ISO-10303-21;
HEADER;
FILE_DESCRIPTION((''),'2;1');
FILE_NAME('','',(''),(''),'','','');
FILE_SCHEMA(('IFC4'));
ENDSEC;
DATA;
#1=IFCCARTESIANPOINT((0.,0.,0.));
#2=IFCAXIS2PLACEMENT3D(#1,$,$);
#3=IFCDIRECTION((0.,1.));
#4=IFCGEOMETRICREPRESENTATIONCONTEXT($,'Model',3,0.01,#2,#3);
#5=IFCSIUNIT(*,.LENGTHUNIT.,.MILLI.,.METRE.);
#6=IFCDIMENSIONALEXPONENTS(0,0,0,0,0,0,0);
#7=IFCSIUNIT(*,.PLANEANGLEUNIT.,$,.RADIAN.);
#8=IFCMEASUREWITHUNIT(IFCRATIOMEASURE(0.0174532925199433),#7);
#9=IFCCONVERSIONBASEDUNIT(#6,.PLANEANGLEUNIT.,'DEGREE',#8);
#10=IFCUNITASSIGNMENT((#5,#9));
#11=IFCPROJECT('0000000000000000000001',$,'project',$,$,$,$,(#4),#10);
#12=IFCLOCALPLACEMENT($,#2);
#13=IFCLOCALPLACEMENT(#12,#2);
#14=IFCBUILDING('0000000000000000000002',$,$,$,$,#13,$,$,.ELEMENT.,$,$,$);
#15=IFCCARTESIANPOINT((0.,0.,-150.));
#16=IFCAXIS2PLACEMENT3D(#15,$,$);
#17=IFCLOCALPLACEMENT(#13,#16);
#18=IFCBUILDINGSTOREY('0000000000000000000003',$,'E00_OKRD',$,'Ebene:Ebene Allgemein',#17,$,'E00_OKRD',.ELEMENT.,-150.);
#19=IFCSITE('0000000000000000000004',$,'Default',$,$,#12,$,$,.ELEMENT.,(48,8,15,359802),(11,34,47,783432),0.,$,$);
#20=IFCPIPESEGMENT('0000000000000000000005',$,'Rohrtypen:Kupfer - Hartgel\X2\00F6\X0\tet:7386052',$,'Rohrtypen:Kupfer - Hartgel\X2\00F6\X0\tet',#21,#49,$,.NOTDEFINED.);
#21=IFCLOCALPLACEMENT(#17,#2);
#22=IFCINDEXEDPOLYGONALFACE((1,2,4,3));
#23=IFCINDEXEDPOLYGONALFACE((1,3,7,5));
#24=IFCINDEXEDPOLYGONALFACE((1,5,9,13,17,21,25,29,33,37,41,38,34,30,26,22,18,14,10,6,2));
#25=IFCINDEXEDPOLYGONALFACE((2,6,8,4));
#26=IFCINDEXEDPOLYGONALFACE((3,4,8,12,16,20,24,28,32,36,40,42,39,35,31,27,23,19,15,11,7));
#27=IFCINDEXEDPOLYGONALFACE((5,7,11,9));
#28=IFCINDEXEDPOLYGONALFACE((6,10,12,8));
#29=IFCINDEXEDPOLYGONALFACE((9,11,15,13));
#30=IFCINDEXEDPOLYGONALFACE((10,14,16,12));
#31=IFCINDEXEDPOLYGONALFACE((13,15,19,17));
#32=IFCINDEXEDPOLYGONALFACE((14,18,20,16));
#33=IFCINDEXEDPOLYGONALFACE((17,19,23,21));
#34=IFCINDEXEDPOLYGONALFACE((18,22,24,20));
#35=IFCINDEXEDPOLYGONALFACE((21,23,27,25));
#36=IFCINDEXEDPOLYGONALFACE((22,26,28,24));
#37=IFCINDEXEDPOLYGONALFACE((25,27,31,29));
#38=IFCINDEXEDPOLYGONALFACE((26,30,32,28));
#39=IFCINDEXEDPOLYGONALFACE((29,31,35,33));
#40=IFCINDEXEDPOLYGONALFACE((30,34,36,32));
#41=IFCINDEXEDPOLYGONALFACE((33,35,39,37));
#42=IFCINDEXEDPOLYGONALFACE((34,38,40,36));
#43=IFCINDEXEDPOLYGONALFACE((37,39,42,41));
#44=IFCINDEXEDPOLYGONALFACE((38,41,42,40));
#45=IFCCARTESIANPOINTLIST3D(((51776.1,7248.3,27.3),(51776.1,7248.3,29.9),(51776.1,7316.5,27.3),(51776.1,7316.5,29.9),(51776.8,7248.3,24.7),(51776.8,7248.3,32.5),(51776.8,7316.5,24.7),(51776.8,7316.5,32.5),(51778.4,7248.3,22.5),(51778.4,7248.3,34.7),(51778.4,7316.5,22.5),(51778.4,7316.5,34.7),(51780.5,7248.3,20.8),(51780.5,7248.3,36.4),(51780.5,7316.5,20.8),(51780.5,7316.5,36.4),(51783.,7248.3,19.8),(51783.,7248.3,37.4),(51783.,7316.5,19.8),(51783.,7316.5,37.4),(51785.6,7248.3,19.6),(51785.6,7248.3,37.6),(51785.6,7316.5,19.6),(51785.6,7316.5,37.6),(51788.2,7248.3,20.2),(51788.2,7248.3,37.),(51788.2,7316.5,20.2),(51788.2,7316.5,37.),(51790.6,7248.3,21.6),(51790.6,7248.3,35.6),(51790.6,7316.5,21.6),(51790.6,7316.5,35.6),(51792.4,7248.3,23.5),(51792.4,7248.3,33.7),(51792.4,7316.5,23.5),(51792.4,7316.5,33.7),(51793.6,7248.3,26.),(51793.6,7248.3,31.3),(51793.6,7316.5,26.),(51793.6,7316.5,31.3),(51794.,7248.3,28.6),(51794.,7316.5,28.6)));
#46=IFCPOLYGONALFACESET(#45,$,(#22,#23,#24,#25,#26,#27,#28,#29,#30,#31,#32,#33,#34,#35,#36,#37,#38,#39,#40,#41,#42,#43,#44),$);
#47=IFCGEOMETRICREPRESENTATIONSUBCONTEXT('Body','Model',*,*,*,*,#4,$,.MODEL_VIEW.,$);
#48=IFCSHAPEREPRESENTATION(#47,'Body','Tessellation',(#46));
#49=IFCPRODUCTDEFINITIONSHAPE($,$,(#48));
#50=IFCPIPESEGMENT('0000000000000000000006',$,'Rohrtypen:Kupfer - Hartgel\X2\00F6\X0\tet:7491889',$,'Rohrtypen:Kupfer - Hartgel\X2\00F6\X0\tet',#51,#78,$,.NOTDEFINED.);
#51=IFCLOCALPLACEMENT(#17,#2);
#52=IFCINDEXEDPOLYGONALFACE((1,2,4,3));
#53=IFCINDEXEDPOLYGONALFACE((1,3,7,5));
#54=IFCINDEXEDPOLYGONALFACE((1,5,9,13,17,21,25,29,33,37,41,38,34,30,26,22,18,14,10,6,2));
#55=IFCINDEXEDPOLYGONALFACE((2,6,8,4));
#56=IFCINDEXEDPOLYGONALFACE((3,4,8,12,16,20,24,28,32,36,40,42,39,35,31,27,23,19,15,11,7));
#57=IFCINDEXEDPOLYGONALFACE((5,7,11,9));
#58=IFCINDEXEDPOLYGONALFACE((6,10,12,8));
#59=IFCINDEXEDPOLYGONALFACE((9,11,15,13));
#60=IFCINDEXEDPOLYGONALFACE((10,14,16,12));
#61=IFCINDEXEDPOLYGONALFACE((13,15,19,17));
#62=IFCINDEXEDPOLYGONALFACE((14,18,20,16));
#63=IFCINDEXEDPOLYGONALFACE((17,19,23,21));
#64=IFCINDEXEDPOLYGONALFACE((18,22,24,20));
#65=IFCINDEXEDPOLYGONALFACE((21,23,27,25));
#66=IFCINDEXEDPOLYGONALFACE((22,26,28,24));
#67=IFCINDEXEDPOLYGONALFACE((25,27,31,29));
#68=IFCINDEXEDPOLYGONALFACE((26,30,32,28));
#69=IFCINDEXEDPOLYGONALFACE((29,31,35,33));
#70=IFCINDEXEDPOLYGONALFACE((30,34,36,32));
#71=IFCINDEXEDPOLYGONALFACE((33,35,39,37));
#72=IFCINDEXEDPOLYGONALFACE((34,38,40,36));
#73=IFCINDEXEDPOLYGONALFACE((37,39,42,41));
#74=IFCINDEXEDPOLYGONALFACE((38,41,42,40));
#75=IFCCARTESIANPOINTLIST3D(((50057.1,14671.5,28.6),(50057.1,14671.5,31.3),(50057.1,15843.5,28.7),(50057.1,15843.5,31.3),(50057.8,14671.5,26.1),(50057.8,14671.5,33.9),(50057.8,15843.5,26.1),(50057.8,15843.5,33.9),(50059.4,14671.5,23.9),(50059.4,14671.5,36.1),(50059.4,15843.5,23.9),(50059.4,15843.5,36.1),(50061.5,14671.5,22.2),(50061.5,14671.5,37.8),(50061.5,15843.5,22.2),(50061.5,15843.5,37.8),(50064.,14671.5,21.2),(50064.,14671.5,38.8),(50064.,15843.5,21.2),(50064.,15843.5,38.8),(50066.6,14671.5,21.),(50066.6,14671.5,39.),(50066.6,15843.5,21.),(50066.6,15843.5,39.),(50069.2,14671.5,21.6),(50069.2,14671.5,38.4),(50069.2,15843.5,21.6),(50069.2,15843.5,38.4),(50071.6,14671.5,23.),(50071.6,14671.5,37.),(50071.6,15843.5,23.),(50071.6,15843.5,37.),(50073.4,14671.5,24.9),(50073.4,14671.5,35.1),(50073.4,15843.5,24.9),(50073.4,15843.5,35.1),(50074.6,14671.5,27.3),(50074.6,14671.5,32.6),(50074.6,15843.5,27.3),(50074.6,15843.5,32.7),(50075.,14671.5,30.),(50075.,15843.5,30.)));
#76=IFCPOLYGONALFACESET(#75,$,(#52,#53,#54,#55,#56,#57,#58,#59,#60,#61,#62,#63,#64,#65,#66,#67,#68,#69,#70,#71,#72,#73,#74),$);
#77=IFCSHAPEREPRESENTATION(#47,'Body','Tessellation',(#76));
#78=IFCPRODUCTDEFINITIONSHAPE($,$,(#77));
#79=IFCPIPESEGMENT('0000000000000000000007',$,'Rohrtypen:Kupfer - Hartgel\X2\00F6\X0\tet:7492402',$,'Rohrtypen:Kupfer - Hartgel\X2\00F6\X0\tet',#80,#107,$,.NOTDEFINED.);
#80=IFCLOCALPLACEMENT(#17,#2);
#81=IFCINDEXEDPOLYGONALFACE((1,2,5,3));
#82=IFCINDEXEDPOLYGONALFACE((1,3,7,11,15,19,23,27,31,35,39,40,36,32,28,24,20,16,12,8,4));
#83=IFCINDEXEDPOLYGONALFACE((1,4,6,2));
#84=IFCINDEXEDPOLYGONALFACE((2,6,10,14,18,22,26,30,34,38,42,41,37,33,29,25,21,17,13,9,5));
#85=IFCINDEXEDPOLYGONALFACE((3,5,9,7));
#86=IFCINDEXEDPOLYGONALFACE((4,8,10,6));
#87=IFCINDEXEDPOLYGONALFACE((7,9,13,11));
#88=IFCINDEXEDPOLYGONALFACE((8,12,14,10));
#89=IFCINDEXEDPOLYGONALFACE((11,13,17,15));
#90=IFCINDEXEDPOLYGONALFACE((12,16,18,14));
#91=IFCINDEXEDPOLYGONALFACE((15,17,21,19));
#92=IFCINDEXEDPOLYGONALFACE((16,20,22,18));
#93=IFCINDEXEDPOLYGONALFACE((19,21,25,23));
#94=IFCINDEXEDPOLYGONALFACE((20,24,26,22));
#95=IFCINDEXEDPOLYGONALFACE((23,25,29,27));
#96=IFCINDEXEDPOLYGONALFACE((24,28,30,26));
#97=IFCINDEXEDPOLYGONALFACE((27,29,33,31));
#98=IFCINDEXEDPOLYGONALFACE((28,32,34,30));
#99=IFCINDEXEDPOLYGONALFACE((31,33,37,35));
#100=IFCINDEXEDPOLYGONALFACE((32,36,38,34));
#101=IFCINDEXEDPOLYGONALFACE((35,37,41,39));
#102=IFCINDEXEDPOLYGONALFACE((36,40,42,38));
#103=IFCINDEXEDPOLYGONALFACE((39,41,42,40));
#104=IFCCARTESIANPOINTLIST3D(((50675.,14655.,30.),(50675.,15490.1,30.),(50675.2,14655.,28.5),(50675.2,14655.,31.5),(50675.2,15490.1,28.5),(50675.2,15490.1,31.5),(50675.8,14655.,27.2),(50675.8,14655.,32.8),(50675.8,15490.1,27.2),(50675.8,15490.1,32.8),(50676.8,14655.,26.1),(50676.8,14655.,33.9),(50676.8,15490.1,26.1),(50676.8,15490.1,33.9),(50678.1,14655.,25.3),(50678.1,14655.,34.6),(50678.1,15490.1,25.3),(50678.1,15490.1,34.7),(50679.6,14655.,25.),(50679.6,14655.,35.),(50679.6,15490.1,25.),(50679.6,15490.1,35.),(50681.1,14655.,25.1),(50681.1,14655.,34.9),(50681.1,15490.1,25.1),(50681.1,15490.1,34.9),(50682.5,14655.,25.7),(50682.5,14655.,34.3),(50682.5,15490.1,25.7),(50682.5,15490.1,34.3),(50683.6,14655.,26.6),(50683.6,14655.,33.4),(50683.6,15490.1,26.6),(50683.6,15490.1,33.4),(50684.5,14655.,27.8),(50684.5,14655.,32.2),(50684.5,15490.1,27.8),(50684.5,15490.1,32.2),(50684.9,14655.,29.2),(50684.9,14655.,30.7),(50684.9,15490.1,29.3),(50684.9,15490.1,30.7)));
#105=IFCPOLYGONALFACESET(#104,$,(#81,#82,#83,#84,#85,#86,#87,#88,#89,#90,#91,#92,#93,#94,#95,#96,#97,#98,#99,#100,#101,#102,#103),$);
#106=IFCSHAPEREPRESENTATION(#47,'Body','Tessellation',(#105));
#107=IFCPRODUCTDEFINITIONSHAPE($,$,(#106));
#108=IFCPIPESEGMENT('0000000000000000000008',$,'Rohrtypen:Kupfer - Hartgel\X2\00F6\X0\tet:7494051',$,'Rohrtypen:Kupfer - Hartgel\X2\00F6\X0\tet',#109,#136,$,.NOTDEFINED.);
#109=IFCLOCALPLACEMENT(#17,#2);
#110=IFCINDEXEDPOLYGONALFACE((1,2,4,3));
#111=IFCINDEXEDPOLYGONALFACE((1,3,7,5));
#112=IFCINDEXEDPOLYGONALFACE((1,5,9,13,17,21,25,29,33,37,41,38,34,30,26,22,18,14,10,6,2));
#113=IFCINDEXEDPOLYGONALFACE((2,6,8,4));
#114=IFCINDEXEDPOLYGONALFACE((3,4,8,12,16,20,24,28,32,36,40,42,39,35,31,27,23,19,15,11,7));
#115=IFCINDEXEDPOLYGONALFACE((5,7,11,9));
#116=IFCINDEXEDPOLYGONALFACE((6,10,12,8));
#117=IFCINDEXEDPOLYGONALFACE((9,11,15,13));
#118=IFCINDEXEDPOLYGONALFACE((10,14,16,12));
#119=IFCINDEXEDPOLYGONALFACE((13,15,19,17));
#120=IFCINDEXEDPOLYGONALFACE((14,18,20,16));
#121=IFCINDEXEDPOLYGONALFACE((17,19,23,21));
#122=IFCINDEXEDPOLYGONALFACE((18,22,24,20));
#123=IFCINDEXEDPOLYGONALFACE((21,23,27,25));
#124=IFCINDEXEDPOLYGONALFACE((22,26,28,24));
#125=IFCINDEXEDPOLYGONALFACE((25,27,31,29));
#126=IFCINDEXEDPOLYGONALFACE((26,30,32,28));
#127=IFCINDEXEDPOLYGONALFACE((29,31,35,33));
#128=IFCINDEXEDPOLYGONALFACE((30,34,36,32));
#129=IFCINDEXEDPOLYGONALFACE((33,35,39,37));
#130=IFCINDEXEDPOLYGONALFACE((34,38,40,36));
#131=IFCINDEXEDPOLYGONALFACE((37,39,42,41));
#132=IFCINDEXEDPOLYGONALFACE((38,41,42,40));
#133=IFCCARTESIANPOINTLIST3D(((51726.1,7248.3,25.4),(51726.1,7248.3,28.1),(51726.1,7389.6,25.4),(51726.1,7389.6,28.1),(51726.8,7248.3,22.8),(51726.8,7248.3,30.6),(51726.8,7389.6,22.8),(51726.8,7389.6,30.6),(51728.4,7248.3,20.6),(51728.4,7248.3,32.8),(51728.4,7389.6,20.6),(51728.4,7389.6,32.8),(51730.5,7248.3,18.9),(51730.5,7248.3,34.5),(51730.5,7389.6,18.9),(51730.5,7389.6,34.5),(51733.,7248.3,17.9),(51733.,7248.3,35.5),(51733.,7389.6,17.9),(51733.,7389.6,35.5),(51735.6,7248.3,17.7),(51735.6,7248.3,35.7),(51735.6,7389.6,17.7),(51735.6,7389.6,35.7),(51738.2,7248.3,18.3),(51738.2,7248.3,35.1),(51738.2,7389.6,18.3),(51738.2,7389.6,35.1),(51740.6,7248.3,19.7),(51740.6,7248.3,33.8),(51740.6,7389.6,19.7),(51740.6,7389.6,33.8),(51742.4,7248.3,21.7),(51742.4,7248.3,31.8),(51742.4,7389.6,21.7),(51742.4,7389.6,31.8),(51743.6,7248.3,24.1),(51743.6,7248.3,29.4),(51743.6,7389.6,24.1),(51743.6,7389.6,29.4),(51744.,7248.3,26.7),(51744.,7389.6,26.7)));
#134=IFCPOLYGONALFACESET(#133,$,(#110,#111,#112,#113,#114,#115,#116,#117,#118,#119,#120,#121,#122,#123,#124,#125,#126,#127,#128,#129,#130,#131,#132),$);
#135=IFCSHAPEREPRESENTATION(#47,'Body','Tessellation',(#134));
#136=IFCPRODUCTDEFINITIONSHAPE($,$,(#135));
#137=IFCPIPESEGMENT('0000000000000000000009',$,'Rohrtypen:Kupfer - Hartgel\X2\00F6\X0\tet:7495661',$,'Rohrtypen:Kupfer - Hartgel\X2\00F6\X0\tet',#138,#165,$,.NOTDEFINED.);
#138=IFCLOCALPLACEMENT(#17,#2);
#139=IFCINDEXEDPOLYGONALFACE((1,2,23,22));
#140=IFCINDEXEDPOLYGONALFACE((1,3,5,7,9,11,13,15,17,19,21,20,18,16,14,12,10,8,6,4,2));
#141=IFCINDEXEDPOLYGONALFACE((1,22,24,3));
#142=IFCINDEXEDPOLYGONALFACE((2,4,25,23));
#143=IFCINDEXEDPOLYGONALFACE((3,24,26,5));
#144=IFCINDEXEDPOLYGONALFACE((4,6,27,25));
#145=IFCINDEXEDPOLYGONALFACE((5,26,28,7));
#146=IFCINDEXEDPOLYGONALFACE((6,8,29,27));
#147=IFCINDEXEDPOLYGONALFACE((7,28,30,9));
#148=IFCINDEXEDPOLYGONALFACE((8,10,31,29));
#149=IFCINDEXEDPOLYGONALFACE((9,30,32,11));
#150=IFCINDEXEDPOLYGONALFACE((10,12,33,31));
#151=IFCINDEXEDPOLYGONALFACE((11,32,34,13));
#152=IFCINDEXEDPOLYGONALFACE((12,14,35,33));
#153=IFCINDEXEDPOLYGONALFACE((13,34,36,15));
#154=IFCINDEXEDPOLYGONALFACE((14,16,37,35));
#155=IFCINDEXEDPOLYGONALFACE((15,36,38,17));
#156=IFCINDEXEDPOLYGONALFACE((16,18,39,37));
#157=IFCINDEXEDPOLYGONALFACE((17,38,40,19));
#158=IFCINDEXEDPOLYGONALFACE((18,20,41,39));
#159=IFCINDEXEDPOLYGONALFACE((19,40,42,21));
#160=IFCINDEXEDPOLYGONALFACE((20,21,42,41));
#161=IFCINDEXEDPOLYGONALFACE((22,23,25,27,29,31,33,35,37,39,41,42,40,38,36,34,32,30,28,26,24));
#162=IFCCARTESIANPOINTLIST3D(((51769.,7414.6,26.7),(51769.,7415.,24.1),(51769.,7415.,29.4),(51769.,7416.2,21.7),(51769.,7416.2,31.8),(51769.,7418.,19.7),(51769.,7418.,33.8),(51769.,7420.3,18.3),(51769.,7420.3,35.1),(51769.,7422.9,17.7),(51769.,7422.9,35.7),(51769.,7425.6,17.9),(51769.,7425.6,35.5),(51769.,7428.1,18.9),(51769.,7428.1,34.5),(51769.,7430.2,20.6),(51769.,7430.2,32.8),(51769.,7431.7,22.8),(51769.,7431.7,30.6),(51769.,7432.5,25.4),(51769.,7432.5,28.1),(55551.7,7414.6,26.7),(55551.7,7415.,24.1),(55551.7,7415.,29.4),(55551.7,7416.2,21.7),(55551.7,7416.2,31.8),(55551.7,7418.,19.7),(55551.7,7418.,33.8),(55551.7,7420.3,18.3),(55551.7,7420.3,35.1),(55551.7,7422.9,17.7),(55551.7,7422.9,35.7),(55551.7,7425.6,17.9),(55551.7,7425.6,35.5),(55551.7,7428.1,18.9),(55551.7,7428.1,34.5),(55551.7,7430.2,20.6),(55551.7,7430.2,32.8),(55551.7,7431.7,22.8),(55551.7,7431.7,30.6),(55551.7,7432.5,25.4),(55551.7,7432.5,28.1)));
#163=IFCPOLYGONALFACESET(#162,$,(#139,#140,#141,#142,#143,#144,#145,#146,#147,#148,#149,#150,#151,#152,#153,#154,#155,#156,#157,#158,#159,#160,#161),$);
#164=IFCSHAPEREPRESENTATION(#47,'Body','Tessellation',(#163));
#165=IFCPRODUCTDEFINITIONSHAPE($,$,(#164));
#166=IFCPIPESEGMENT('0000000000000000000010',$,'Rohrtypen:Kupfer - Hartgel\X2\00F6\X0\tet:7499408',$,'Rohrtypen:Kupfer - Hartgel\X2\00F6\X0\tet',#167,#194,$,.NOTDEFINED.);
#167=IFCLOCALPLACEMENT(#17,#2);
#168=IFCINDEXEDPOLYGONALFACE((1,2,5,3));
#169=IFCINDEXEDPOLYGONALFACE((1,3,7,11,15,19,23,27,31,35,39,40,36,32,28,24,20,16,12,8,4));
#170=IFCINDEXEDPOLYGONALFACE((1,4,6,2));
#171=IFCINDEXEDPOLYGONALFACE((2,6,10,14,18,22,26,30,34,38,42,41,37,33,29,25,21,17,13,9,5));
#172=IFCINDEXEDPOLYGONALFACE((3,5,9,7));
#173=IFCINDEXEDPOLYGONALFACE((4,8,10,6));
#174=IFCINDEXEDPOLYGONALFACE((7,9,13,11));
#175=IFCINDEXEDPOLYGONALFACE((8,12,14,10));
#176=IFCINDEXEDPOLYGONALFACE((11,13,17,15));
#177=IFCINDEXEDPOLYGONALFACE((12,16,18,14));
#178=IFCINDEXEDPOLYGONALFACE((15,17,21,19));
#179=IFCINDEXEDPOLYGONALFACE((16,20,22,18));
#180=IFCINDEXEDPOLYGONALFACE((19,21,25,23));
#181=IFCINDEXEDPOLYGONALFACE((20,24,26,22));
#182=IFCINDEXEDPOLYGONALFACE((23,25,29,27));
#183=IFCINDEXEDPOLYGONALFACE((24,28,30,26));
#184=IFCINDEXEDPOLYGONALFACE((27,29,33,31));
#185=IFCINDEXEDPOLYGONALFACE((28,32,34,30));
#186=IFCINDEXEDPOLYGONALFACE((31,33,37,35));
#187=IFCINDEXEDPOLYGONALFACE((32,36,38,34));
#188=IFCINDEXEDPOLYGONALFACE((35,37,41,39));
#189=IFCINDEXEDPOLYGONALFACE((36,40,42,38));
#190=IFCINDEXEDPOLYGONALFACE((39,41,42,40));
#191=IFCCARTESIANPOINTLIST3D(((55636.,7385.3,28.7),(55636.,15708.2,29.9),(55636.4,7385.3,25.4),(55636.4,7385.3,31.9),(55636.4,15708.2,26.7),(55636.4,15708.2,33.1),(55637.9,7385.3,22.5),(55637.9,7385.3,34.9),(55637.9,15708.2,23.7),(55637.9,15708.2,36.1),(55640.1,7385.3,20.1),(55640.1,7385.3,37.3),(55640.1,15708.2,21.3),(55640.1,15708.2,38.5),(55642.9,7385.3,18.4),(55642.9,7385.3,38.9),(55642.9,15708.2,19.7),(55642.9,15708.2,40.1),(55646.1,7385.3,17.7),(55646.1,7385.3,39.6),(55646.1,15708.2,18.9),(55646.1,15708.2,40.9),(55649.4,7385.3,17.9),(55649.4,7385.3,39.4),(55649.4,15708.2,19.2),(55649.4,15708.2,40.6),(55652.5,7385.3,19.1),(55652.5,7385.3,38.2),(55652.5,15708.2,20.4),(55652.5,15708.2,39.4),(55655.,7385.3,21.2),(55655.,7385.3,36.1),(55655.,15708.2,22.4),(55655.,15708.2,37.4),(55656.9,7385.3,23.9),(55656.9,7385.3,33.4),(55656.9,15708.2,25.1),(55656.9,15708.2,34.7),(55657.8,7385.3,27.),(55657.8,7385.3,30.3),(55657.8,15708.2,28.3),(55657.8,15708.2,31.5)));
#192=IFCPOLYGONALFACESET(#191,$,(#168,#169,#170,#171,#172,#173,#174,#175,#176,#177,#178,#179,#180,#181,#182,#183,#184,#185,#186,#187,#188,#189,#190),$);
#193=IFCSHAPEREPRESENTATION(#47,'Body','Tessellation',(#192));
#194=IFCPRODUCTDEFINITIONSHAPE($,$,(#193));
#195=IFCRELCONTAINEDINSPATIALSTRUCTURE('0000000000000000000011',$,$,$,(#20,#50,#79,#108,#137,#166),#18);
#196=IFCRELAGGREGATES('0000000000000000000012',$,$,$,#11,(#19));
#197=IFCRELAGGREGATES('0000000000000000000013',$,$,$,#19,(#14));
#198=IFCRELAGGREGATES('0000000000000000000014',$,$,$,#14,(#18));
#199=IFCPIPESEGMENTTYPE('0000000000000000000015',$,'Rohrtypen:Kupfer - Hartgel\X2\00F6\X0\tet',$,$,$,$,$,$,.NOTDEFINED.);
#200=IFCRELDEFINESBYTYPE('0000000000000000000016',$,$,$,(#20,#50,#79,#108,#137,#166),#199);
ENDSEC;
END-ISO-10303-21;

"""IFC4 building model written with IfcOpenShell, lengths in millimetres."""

from ifc_helpers import new_model, entity, si_unit, converted_unit, direction, frame, frame_2d, origin, origin_2d_with_axis, place, context, subcontext, project, spatial, circle, extrude, type_object, element, save


model = new_model("IFC4")

# Units and contexts
model_context = context("Model", 3, precision=0.01, world=origin(), true_north=direction((0.0, 1.0)))
body_context = subcontext(model_context, "Body", "Model", "MODEL_VIEW")
ifc_project = project(units=[si_unit("LENGTHUNIT", "METRE", prefix="MILLI"), converted_unit("PLANEANGLEUNIT", "DEGREE", entity("IfcRatioMeasure", 0.0174532925199433), si_unit("PLANEANGLEUNIT", "RADIAN"), dimensions=[0, 0, 0, 0, 0, 0, 0])], contexts=[model_context])

# Site, building, storey
site_placement = place(None, origin())
site = spatial("IfcSite", under=ifc_project, at=site_placement, Name="Default", CompositionType="ELEMENT", RefLatitude=(48, 8, 15, 359802), RefLongitude=(11, 34, 47, 783432), RefElevation=0.0)
building_placement = place(site_placement, origin())
building = spatial("IfcBuilding", under=site, at=building_placement, CompositionType="ELEMENT")
storey_placement = place(building_placement, frame((0.0, 0.0, -150.0)))
storey = spatial("IfcBuildingStorey", under=building, at=storey_placement, Name="E00_OKRD", ObjectType="Ebene:Ebene Allgemein", LongName="E00_OKRD", CompositionType="ELEMENT", Elevation=-150.0)

# Pipe segments
pipe_segment_type = type_object("IfcPipeSegmentType", Name="Rohrtypen:Kupfer - Hartgelötet", PredefinedType="NOTDEFINED")
pipe_segment_1_placement = place(storey_placement, frame((51774.4, 7248.3, 18.0)))
element("IfcPipeSegment", 1, at=pipe_segment_1_placement, inside=storey, type_object=pipe_segment_type, Name="Rohrtypen:Kupfer - Hartgelötet:7386052", ObjectType="Rohrtypen:Kupfer - Hartgelötet", PredefinedType="NOTDEFINED", context=body_context, shape_type="SweptSolid", body=[
    extrude(circle(Radius=9.0, at=frame_2d((0.0, 0.0), x_axis=(1.0, 0.0))), frame((10.6, 0.0, 10.6), z_axis=(0.0, 1.0, 0.0), x_axis=(1.0, 0.0, 0.0)), (0.0, 0.0, 1.0), 68.2),
])
pipe_segment_2_placement = place(storey_placement, frame((50055.4, 14671.5, 19.4)))
element("IfcPipeSegment", 2, at=pipe_segment_2_placement, inside=storey, type_object=pipe_segment_type, Name="Rohrtypen:Kupfer - Hartgelötet:7491889", ObjectType="Rohrtypen:Kupfer - Hartgelötet", PredefinedType="NOTDEFINED", context=body_context, shape_type="SweptSolid", body=[
    extrude(circle(Radius=9.0, at=origin_2d_with_axis()), frame((10.6, 0.0, 10.6), z_axis=(0.0, 1.0, 0.000011), x_axis=(1.0, 0.0, 0.0)), (0.0, 0.0, 1.0), 1172.0),
])
pipe_segment_3_placement = place(storey_placement, frame((50673.4, 14655.0, 23.4)))
element("IfcPipeSegment", 3, at=pipe_segment_3_placement, inside=storey, type_object=pipe_segment_type, Name="Rohrtypen:Kupfer - Hartgelötet:7492402", ObjectType="Rohrtypen:Kupfer - Hartgelötet", PredefinedType="NOTDEFINED", context=body_context, shape_type="SweptSolid", body=[
    extrude(circle(Radius=5.0, at=frame_2d((0.0, 0.0), x_axis=(1.0, 0.0))), frame((6.6, 0.0, 6.6), z_axis=(0.0, 1.0, 0.000013), x_axis=(-1.0, 0.0, 0.0)), (0.0, 0.0, 1.0), 835.1),
])
pipe_segment_4_placement = place(storey_placement, frame((51724.4, 7248.3, 16.1)))
element("IfcPipeSegment", 4, at=pipe_segment_4_placement, inside=storey, type_object=pipe_segment_type, Name="Rohrtypen:Kupfer - Hartgelötet:7494051", ObjectType="Rohrtypen:Kupfer - Hartgelötet", PredefinedType="NOTDEFINED", context=body_context, shape_type="SweptSolid", body=[
    extrude(circle(Radius=9.0, at=origin_2d_with_axis()), frame((10.6, 0.0, 10.6), z_axis=(0.0, 1.0, 0.0), x_axis=(1.0, 0.0, 0.0)), (0.0, 0.0, 1.0), 141.3),
])
pipe_segment_5_placement = place(storey_placement, frame((51769.0, 7413.0, 16.1)))
element("IfcPipeSegment", 5, at=pipe_segment_5_placement, inside=storey, type_object=pipe_segment_type, Name="Rohrtypen:Kupfer - Hartgelötet:7495661", ObjectType="Rohrtypen:Kupfer - Hartgelötet", PredefinedType="NOTDEFINED", context=body_context, shape_type="SweptSolid", body=[
    extrude(circle(Radius=9.0, at=origin_2d_with_axis()), frame((0.0, 10.6, 10.6), z_axis=(1.0, 0.0, 0.0), x_axis=(0.0, -1.0, 0.0)), (0.0, 0.0, 1.0), 3782.7),
])
pipe_segment_6_placement = place(storey_placement, frame((55634.4, 7385.3, 16.1)))
element("IfcPipeSegment", 6, at=pipe_segment_6_placement, inside=storey, type_object=pipe_segment_type, Name="Rohrtypen:Kupfer - Hartgelötet:7499408", ObjectType="Rohrtypen:Kupfer - Hartgelötet", PredefinedType="NOTDEFINED", context=body_context, shape_type="SweptSolid", body=[
    extrude(circle(Radius=11.0, at=origin_2d_with_axis()), frame((12.6, 0.0, 12.6), z_axis=(0.0, 1.0, 0.000149), x_axis=(-1.0, 0.0, 0.0)), (0.0, 0.0, 1.0), 8322.8),
])

save(model, "model.ifc")
